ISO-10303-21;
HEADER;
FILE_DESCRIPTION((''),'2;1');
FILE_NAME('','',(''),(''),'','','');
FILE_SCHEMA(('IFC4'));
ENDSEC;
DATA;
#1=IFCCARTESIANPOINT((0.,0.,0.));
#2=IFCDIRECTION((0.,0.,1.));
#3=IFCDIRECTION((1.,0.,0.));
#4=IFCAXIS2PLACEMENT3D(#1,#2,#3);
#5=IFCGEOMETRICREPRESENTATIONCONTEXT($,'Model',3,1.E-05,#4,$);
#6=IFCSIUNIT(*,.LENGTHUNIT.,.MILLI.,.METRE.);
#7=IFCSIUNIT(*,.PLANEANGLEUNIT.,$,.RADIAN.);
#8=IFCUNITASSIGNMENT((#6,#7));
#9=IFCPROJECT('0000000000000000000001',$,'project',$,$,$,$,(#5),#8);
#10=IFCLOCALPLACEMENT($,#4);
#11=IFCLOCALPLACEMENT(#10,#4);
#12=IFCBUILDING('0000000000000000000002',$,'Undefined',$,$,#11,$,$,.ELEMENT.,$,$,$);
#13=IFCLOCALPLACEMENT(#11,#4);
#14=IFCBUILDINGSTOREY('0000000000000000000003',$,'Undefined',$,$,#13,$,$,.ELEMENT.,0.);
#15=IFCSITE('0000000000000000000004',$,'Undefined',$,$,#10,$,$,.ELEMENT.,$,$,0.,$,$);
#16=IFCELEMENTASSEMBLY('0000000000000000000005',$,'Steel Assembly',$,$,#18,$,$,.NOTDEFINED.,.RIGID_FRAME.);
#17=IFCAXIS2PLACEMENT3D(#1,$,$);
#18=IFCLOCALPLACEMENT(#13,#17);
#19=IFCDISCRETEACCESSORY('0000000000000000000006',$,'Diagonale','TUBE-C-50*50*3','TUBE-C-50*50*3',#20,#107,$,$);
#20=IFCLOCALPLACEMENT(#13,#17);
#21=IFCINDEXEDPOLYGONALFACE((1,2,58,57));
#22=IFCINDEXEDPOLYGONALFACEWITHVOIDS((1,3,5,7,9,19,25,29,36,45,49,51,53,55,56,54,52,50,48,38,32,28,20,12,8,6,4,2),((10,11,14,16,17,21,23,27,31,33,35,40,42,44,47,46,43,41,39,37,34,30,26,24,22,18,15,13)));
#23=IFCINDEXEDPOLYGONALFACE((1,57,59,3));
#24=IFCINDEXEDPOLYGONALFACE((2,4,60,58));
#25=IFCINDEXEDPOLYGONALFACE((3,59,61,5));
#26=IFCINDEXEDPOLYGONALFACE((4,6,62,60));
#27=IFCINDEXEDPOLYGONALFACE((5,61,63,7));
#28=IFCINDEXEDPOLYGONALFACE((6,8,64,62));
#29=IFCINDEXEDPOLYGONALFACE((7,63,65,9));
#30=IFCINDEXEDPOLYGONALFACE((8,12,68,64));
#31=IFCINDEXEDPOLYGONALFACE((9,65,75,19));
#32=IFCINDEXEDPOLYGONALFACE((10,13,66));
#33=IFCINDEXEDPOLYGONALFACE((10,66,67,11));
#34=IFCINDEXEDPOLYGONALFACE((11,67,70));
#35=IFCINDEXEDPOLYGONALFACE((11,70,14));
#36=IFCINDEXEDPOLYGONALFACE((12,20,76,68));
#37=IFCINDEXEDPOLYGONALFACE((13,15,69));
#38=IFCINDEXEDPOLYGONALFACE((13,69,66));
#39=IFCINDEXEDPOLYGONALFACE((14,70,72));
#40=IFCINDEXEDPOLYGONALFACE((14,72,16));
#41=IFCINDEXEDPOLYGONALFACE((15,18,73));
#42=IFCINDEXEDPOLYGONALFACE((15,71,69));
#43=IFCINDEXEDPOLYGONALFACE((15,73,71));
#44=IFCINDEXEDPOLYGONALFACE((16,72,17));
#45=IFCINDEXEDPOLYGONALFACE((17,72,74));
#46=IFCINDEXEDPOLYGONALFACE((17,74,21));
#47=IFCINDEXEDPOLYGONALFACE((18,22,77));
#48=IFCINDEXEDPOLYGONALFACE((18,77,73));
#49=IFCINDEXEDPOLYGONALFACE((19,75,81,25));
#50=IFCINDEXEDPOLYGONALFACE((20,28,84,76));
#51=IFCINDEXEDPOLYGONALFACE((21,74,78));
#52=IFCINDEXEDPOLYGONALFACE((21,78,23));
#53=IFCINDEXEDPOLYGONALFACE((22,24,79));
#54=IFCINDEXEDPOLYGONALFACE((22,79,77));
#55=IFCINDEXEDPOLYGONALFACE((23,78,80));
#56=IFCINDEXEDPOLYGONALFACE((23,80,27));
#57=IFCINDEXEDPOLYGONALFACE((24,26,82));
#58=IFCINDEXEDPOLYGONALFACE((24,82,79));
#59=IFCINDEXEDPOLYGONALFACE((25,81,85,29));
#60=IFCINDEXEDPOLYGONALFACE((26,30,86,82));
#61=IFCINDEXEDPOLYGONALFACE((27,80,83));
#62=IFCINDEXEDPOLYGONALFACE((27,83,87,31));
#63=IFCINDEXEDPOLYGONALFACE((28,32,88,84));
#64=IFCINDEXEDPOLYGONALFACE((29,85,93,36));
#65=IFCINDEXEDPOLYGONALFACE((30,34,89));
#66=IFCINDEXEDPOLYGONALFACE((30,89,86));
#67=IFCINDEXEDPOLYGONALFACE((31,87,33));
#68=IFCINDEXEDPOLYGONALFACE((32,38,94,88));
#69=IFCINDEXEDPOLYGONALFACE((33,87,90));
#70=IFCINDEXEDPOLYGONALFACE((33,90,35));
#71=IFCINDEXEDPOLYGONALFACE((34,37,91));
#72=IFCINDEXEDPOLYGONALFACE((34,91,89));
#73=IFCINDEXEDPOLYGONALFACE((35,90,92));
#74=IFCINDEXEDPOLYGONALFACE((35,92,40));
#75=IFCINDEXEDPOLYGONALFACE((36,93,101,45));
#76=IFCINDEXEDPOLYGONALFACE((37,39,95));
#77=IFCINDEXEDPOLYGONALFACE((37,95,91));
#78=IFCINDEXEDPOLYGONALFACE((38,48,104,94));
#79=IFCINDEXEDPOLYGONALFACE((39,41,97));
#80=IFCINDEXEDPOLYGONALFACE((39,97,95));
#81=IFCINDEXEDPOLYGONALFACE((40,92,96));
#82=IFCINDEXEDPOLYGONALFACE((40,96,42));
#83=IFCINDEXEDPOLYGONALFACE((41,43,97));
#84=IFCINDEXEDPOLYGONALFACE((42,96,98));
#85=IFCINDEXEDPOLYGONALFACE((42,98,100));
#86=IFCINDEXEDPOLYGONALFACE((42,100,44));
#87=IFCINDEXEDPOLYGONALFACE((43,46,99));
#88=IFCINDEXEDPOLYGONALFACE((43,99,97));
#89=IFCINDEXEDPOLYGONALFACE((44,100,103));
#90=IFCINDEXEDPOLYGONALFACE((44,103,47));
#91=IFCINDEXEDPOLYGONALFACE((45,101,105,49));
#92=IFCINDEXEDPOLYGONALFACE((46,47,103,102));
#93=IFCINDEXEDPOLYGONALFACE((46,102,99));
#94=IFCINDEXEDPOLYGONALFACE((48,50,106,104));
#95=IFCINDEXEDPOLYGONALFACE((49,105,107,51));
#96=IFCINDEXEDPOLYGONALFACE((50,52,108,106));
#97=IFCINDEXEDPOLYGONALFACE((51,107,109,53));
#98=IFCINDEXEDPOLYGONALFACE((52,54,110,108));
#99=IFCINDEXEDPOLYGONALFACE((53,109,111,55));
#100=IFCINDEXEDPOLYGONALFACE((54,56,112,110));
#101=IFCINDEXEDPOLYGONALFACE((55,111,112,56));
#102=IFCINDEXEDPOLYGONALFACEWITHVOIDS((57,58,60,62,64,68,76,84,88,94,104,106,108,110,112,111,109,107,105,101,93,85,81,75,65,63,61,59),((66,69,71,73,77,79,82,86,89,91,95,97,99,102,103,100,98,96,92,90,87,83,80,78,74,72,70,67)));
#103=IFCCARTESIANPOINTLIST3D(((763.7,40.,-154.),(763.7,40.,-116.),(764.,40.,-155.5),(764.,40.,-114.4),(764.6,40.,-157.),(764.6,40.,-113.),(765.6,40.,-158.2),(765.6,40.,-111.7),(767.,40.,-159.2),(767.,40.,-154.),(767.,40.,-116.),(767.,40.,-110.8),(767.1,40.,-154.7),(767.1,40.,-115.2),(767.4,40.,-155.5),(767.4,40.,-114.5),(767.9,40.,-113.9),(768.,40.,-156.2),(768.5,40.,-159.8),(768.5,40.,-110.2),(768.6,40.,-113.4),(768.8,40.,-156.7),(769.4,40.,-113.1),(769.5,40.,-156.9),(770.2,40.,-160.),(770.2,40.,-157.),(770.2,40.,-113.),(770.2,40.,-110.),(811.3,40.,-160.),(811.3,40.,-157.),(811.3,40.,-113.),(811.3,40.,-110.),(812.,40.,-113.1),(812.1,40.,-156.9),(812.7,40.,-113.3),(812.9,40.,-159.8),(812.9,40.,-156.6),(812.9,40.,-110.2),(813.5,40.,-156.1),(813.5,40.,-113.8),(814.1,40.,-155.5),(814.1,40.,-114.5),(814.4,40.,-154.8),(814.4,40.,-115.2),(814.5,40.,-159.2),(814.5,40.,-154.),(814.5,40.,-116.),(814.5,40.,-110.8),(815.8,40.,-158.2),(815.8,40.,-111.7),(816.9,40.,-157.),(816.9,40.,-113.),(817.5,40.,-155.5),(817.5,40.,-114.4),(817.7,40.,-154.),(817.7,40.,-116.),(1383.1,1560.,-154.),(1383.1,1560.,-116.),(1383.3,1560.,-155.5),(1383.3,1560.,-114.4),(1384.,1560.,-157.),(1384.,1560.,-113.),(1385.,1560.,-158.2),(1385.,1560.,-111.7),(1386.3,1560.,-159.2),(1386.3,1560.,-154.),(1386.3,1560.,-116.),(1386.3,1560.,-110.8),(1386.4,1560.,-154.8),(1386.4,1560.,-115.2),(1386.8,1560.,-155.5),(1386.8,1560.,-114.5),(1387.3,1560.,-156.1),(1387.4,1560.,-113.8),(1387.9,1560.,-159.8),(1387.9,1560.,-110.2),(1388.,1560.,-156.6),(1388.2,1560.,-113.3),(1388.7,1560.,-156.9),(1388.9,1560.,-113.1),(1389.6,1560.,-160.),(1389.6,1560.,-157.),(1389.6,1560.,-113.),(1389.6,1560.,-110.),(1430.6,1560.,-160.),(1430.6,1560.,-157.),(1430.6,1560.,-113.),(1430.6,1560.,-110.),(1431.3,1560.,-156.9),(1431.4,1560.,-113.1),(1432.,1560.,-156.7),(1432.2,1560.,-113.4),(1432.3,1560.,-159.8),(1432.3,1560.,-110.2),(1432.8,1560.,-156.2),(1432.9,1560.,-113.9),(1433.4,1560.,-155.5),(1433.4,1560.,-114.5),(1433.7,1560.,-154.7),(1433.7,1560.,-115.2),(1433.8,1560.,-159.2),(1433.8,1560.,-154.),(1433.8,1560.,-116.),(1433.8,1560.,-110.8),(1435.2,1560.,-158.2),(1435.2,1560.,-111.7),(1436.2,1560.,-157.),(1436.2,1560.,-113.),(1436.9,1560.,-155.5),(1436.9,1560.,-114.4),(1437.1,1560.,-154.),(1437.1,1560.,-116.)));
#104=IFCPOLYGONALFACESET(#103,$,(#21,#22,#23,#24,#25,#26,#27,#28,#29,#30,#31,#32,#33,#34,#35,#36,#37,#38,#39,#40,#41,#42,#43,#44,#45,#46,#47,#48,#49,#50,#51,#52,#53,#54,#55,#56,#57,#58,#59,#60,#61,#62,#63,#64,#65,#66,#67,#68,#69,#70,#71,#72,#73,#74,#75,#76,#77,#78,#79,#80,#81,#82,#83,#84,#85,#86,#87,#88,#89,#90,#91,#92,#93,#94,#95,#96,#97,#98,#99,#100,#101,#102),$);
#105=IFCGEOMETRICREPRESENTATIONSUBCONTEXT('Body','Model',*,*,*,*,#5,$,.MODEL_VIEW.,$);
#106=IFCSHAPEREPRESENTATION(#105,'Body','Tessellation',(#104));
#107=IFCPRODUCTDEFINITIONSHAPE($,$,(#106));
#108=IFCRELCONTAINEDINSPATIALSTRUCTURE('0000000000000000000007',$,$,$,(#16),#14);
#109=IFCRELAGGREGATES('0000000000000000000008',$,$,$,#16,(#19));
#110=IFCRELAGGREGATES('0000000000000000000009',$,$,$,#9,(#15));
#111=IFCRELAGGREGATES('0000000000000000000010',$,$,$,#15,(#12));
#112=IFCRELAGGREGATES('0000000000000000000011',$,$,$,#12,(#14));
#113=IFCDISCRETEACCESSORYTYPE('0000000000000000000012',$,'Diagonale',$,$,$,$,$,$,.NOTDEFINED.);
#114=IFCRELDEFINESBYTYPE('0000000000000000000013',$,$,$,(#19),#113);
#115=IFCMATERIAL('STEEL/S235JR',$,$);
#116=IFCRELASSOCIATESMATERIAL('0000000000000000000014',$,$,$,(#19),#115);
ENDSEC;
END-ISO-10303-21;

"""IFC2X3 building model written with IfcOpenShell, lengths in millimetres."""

from ifc_helpers import new_model, si_unit, frame, origin_with_axes, origin_2d_with_axis, place, context, subcontext, project, spatial, hollow_rectangle, extrude, clip, halfspace, material, type_object, element, aggregate, save


model = new_model("IFC2X3")

# Units and contexts
model_context = context("Model", 3, precision=1e-05, world=origin_with_axes())
body_context = subcontext(model_context, "Body", "Model", "MODEL_VIEW")
ifc_project = project(units=[si_unit("LENGTHUNIT", "METRE", prefix="MILLI"), si_unit("PLANEANGLEUNIT", "RADIAN")], contexts=[model_context])

# Site, building, storey
site_placement = place(None, origin_with_axes())
site = spatial("IfcSite", under=ifc_project, at=site_placement, Name="Undefined", CompositionType="ELEMENT", RefElevation=0.0)
building_placement = place(site_placement, origin_with_axes())
building = spatial("IfcBuilding", under=site, at=building_placement, Name="Undefined", CompositionType="ELEMENT")
storey_placement = place(building_placement, origin_with_axes())
storey = spatial("IfcBuildingStorey", under=building, at=storey_placement, Name="Undefined", CompositionType="ELEMENT", Elevation=0.0)

# Shared definitions
ifc_material = material(Name="STEEL/S235JR")

# Element assembly, discrete accessory
assembly_1_placement = place(storey_placement, origin_with_axes())
assembly_1 = element("IfcElementAssembly", 1, at=assembly_1_placement, inside=storey, Name="Steel Assembly", AssemblyPlace="NOTDEFINED", PredefinedType="RIGID_FRAME")
discrete_accessory_type_1 = type_object("IfcDiscreteAccessoryType", Name="Diagonale")
discrete_accessory_1_placement = place(assembly_1_placement, frame((1417.9, 1579.1, -135.0), z_axis=(-0.926073, 0.377344, 0.0), x_axis=(-0.377344, -0.926073, 0.0)))
discrete_accessory_1 = element("IfcDiscreteAccessory", 2, at=discrete_accessory_1_placement, type_object=discrete_accessory_type_1, material=ifc_material, Name="Diagonale", Description="TUBE-C-50*50*3", ObjectType="TUBE-C-50*50*3", context=body_context, shape_type="Clipping", body=[
    clip(clip(extrude(hollow_rectangle(XDim=50.0, YDim=50.0, WallThickness=3.0, InnerFilletRadius=3.0, OuterFilletRadius=6.0, at=origin_2d_with_axis()), frame((1682.5, 0.0, 0.0), z_axis=(-1.0, 0.0, 0.0), x_axis=(0.0, -1.0, 0.0)), (0.0, 0.0, 1.0), 1682.5), halfspace(frame((10.4, 25.0, -25.0), z_axis=(-0.926073, 0.0, 0.377344), x_axis=(0.377344, 0.0, 0.926073)), False)), halfspace(frame((1651.7, -25.0, -25.0), z_axis=(0.926073, 0.0, -0.377344), x_axis=(0.377344, 0.0, 0.926073)), False)),
])
aggregate(assembly_1, [discrete_accessory_1])

save(model, "model.ifc")
